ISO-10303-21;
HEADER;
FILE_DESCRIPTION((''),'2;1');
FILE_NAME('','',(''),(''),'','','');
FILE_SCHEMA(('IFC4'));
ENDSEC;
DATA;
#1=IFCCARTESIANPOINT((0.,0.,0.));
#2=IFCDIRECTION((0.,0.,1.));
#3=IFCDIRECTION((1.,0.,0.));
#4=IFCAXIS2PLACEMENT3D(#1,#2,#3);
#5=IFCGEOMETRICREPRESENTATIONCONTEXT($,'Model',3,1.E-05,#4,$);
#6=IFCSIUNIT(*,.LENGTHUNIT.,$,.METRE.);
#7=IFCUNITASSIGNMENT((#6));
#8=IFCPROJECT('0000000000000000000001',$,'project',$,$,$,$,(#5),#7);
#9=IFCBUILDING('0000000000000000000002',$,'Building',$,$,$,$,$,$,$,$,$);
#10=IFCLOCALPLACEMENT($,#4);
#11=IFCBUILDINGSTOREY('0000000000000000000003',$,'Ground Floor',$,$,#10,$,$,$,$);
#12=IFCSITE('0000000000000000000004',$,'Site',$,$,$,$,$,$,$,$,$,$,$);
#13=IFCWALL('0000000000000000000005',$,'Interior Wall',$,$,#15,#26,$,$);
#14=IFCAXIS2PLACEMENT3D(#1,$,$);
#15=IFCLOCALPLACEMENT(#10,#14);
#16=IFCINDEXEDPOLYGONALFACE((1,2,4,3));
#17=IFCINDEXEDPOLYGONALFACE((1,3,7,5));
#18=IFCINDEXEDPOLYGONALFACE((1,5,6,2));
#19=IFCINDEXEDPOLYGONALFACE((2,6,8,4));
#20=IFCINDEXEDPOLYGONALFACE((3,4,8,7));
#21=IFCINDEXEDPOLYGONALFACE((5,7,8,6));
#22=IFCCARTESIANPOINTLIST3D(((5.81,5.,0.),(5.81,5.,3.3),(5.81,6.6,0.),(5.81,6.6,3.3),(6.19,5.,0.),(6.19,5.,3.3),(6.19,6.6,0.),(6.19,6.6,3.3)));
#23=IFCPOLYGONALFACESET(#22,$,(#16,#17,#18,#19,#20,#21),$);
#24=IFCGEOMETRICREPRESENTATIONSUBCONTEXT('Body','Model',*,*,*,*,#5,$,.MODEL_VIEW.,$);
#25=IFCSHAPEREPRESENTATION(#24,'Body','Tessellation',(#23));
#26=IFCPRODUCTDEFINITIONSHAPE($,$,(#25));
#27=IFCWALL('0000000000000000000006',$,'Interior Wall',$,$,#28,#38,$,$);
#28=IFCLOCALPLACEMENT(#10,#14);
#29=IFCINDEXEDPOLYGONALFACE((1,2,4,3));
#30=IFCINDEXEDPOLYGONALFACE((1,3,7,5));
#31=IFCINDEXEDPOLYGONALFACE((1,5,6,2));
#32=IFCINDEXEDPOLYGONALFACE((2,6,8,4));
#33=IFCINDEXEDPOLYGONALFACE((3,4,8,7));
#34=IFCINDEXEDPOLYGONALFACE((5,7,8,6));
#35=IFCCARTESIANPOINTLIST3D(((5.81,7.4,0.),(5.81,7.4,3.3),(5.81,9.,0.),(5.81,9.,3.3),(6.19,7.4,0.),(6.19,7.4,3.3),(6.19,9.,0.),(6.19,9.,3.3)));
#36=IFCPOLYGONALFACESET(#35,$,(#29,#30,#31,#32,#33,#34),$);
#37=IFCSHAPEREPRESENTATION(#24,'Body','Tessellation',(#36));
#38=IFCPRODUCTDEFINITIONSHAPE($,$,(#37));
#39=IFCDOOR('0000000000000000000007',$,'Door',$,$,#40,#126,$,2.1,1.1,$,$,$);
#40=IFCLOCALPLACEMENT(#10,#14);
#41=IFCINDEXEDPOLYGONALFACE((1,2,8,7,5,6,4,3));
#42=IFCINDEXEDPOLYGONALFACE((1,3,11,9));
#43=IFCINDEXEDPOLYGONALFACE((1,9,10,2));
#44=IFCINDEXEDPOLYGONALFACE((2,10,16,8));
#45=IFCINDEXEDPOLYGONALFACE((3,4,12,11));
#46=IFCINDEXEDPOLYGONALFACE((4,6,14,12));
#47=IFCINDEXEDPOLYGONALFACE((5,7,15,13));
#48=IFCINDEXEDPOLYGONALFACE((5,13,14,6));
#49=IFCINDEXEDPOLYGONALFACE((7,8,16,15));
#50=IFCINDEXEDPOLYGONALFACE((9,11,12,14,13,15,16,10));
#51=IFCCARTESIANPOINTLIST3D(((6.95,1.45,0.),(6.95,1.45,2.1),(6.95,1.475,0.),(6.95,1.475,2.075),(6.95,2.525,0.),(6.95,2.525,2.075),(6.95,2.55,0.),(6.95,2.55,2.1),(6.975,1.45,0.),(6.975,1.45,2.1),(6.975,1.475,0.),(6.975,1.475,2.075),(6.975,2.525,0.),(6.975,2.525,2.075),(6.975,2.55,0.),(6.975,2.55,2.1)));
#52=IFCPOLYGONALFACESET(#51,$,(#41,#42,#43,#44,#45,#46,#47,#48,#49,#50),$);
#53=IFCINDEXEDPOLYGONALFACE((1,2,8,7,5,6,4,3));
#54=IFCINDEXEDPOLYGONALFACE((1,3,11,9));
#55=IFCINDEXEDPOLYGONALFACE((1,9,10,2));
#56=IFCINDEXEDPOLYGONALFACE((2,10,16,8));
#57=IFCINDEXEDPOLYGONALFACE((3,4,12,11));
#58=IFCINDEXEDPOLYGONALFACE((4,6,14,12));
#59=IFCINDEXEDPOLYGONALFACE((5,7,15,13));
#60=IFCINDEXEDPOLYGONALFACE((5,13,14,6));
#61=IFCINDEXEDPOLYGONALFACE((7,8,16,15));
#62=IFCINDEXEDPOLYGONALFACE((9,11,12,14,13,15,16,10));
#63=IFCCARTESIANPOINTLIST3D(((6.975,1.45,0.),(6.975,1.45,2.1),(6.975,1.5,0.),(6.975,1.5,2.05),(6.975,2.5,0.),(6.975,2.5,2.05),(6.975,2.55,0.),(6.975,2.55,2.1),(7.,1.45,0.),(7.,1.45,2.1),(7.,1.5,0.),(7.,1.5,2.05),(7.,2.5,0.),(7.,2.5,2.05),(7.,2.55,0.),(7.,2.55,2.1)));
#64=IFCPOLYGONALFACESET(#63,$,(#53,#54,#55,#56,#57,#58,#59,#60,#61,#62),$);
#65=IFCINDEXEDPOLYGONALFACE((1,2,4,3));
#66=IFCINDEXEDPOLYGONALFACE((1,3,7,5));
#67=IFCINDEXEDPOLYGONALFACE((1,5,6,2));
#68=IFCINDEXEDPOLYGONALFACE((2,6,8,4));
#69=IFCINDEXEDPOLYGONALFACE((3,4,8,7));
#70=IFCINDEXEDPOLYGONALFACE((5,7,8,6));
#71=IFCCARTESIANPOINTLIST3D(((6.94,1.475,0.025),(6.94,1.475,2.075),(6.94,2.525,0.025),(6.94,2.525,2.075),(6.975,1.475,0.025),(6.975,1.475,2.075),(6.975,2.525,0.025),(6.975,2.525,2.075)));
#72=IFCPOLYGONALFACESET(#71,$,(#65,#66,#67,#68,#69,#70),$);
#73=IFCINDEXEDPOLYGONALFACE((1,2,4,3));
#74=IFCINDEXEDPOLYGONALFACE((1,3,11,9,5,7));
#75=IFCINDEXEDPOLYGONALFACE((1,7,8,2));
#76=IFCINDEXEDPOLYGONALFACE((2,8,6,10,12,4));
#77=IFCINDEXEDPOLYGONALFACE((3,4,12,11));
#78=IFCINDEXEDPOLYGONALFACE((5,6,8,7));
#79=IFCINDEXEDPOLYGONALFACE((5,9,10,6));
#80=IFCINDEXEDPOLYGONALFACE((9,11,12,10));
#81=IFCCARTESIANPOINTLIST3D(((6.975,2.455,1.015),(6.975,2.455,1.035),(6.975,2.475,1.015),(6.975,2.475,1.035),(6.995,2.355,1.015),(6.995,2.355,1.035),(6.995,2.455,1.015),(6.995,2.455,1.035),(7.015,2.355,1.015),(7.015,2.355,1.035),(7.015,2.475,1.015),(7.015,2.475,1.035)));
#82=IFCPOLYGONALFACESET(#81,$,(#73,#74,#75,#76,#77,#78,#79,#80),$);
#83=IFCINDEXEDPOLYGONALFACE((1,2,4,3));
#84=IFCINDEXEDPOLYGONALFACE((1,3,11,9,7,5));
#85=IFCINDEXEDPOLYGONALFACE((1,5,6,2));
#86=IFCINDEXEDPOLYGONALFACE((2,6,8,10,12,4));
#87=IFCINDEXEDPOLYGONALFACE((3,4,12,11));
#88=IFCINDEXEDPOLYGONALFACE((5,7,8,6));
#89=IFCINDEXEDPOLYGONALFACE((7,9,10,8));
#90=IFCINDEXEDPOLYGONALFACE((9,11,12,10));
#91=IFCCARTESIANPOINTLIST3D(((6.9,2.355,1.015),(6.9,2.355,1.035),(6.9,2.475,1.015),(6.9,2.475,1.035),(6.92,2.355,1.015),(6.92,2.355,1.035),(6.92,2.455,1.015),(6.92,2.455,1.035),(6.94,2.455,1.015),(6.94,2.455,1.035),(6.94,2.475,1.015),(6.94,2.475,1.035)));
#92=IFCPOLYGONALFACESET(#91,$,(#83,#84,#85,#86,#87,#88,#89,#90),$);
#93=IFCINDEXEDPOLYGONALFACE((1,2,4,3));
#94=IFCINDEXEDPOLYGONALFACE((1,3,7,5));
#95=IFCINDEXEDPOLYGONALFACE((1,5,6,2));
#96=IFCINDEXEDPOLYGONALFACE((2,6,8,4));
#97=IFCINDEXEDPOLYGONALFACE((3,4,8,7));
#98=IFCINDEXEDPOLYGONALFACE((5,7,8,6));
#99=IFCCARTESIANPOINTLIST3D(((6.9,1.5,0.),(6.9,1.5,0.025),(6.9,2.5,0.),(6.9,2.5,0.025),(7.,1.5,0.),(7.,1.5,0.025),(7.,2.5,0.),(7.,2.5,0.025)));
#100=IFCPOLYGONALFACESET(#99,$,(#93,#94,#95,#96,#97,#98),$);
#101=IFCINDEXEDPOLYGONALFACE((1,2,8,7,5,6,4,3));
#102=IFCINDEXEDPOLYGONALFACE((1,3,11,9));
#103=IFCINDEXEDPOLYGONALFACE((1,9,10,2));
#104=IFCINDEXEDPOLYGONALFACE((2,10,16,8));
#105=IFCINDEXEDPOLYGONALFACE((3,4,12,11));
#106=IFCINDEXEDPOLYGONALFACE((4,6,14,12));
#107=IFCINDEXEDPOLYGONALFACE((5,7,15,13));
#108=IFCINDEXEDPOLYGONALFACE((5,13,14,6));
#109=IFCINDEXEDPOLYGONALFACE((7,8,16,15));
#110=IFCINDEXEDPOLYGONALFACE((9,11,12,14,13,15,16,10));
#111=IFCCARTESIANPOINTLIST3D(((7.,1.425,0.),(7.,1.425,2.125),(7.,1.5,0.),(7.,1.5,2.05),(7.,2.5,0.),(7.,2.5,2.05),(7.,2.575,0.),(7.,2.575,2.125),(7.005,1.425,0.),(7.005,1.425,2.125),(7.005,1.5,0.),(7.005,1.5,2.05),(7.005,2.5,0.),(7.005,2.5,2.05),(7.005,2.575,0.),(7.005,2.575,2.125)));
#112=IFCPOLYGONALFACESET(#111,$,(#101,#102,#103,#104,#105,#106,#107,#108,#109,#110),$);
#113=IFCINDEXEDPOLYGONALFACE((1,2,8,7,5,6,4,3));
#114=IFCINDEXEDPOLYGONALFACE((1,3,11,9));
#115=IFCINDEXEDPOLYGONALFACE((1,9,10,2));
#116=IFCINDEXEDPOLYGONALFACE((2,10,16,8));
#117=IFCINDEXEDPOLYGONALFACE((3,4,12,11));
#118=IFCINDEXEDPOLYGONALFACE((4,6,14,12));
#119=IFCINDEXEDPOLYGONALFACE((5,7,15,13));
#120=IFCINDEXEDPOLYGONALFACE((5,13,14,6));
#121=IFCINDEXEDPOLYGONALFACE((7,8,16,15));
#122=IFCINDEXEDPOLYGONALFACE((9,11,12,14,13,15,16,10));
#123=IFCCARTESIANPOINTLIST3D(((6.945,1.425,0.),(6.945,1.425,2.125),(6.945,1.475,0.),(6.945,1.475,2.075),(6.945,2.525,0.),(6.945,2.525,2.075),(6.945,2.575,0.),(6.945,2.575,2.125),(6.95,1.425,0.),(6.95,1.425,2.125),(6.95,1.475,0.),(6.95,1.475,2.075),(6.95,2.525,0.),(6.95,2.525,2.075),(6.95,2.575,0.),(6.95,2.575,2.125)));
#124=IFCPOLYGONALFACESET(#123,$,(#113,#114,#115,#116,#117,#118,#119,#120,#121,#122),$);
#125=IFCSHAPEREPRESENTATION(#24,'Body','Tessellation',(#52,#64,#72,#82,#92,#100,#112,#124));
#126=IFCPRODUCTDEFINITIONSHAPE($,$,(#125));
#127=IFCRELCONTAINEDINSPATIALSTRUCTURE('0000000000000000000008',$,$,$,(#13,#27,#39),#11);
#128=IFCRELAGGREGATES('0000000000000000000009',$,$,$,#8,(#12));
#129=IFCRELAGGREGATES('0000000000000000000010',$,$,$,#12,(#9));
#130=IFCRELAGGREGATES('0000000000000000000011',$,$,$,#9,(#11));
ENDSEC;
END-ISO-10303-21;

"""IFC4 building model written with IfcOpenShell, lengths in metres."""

from ifc_helpers import new_model, si_unit, frame, origin_with_axes, place, context, subcontext, project, spatial, line, indexed_curve, outline, extrude, element, save


model = new_model("IFC4")

# Units and contexts
model_context = context("Model", 3, precision=1e-05, world=origin_with_axes())
body_context = subcontext(model_context, "Body", "Model", "MODEL_VIEW")
ifc_project = project(units=[si_unit("LENGTHUNIT", "METRE")], contexts=[model_context])

# Site, building, storey
site = spatial("IfcSite", under=ifc_project, Name="Site")
building = spatial("IfcBuilding", under=site, Name="Building")
storey_placement = place(None, origin_with_axes())
storey = spatial("IfcBuildingStorey", under=building, at=storey_placement, Name="Ground Floor")

# Walls
for number, where, z_axis, x_axis, name in (
    (1, (6.0, 5.0, 0.0), (0.0, 0.0, 1.0), (0.0, 1.0, 0.0), "Interior Wall"),
    (2, (6.0, 7.4, 0.0), (0.0, 0.0, 1.0), (0.0, 1.0, 0.0), "Interior Wall"),
):
    element("IfcWall", number, at=place(storey_placement, frame(where, z_axis=z_axis, x_axis=x_axis)), inside=storey, Name=name, context=body_context, shape_type="SweptSolid", body=[
        extrude(outline(indexed_curve([(0.0, 0.0), (0.0, 0.38), (1.6, 0.38), (1.6, 0.0), (0.0, 0.0)], self_intersect=False)), frame((0.0, -0.19, 0.0), z_axis=(0.0, 0.0, 1.0), x_axis=(1.0, 0.0, 0.0)), (0.0, 0.0, 1.0), 3.3),
    ])

# Door
door_1_placement = place(storey_placement, frame((7.0, 1.45, 0.0), z_axis=(0.0, 0.0, 1.0), x_axis=(0.0, 1.0, 0.0)))
element("IfcDoor", 3, at=door_1_placement, inside=storey, Name="Door", OverallHeight=2.1, OverallWidth=1.1, context=body_context, shape_type="SweptSolid", body=[
    extrude(outline(indexed_curve([(0.0, 0.0), (0.0, 2.1), (1.1, 2.1), (1.1, 0.0), (1.075, 0.0), (1.075, 2.075), (0.025, 2.075), (0.025, 0.0)], segments=[line(1, 2, 3, 4, 5, 6, 7, 8, 1)])), frame((0.0, 0.025, 0.0), z_axis=(0.0, -1.0, 0.0), x_axis=(1.0, 0.0, 0.0)), (0.0, 0.0, -1.0), 0.025),
    extrude(outline(indexed_curve([(0.0, 0.0), (0.0, 2.1), (1.1, 2.1), (1.1, 0.0), (1.05, 0.0), (1.05, 2.05), (0.05, 2.05), (0.05, 0.0)], segments=[line(1, 2, 3, 4, 5, 6, 7, 8, 1)])), frame((0.0, 0.0, 0.0), z_axis=(0.0, -1.0, 0.0), x_axis=(1.0, 0.0, 0.0)), (0.0, 0.0, -1.0), 0.025),
    extrude(outline(indexed_curve([(0.0, 0.0), (1.05, 0.0), (1.05, 0.035), (0.0, 0.035)], segments=[line(1, 2, 3, 4, 1)])), frame((0.025, 0.025, 0.025), z_axis=(0.0, 0.0, 1.0), x_axis=(1.0, 0.0, 0.0)), (0.0, 0.0, 1.0), 2.05),
    extrude(outline(indexed_curve([(0.0, 0.0), (0.0, -0.04), (-0.12, -0.04), (-0.12, -0.02), (-0.02, -0.02), (-0.02, 0.0)], segments=[line(1, 2, 3, 4, 5, 6, 1)])), frame((1.025, 0.025, 1.015), z_axis=(0.0, 0.0, 1.0), x_axis=(1.0, 0.0, 0.0)), (0.0, 0.0, 1.0), 0.02),
    extrude(outline(indexed_curve([(0.0, 0.0), (0.0, 0.04), (-0.12, 0.04), (-0.12, 0.02), (-0.02, 0.02), (-0.02, 0.0)], segments=[line(1, 2, 3, 4, 5, 6, 1)])), frame((1.025, 0.06, 1.015), z_axis=(0.0, 0.0, 1.0), x_axis=(1.0, 0.0, 0.0)), (0.0, 0.0, 1.0), 0.02),
    extrude(outline(indexed_curve([(0.0, 0.0), (1.0, 0.0), (1.0, 0.1), (0.0, 0.1)], segments=[line(1, 2, 3, 4, 1)])), frame((0.05, 0.0, 0.0), z_axis=(0.0, 0.0, 1.0), x_axis=(1.0, 0.0, 0.0)), (0.0, 0.0, 1.0), 0.025),
    extrude(outline(indexed_curve([(0.0, 0.0), (0.0, 2.125), (1.15, 2.125), (1.15, 0.0), (1.075, 0.0), (1.075, 2.05), (0.075, 2.05), (0.075, 0.0)], segments=[line(1, 2, 3, 4, 5, 6, 7, 8, 1)])), frame((-0.025, -0.005, 0.0), z_axis=(0.0, -1.0, 0.0), x_axis=(1.0, 0.0, 0.0)), (0.0, 0.0, -1.0), 0.005),
    extrude(outline(indexed_curve([(0.0, 0.0), (0.0, 2.125), (1.15, 2.125), (1.15, 0.0), (1.1, 0.0), (1.1, 2.075), (0.05, 2.075), (0.05, 0.0)], segments=[line(1, 2, 3, 4, 5, 6, 7, 8, 1)])), frame((-0.025, 0.05, 0.0), z_axis=(0.0, -1.0, 0.0), x_axis=(1.0, 0.0, 0.0)), (0.0, 0.0, -1.0), 0.005),
])

save(model, "model.ifc")
